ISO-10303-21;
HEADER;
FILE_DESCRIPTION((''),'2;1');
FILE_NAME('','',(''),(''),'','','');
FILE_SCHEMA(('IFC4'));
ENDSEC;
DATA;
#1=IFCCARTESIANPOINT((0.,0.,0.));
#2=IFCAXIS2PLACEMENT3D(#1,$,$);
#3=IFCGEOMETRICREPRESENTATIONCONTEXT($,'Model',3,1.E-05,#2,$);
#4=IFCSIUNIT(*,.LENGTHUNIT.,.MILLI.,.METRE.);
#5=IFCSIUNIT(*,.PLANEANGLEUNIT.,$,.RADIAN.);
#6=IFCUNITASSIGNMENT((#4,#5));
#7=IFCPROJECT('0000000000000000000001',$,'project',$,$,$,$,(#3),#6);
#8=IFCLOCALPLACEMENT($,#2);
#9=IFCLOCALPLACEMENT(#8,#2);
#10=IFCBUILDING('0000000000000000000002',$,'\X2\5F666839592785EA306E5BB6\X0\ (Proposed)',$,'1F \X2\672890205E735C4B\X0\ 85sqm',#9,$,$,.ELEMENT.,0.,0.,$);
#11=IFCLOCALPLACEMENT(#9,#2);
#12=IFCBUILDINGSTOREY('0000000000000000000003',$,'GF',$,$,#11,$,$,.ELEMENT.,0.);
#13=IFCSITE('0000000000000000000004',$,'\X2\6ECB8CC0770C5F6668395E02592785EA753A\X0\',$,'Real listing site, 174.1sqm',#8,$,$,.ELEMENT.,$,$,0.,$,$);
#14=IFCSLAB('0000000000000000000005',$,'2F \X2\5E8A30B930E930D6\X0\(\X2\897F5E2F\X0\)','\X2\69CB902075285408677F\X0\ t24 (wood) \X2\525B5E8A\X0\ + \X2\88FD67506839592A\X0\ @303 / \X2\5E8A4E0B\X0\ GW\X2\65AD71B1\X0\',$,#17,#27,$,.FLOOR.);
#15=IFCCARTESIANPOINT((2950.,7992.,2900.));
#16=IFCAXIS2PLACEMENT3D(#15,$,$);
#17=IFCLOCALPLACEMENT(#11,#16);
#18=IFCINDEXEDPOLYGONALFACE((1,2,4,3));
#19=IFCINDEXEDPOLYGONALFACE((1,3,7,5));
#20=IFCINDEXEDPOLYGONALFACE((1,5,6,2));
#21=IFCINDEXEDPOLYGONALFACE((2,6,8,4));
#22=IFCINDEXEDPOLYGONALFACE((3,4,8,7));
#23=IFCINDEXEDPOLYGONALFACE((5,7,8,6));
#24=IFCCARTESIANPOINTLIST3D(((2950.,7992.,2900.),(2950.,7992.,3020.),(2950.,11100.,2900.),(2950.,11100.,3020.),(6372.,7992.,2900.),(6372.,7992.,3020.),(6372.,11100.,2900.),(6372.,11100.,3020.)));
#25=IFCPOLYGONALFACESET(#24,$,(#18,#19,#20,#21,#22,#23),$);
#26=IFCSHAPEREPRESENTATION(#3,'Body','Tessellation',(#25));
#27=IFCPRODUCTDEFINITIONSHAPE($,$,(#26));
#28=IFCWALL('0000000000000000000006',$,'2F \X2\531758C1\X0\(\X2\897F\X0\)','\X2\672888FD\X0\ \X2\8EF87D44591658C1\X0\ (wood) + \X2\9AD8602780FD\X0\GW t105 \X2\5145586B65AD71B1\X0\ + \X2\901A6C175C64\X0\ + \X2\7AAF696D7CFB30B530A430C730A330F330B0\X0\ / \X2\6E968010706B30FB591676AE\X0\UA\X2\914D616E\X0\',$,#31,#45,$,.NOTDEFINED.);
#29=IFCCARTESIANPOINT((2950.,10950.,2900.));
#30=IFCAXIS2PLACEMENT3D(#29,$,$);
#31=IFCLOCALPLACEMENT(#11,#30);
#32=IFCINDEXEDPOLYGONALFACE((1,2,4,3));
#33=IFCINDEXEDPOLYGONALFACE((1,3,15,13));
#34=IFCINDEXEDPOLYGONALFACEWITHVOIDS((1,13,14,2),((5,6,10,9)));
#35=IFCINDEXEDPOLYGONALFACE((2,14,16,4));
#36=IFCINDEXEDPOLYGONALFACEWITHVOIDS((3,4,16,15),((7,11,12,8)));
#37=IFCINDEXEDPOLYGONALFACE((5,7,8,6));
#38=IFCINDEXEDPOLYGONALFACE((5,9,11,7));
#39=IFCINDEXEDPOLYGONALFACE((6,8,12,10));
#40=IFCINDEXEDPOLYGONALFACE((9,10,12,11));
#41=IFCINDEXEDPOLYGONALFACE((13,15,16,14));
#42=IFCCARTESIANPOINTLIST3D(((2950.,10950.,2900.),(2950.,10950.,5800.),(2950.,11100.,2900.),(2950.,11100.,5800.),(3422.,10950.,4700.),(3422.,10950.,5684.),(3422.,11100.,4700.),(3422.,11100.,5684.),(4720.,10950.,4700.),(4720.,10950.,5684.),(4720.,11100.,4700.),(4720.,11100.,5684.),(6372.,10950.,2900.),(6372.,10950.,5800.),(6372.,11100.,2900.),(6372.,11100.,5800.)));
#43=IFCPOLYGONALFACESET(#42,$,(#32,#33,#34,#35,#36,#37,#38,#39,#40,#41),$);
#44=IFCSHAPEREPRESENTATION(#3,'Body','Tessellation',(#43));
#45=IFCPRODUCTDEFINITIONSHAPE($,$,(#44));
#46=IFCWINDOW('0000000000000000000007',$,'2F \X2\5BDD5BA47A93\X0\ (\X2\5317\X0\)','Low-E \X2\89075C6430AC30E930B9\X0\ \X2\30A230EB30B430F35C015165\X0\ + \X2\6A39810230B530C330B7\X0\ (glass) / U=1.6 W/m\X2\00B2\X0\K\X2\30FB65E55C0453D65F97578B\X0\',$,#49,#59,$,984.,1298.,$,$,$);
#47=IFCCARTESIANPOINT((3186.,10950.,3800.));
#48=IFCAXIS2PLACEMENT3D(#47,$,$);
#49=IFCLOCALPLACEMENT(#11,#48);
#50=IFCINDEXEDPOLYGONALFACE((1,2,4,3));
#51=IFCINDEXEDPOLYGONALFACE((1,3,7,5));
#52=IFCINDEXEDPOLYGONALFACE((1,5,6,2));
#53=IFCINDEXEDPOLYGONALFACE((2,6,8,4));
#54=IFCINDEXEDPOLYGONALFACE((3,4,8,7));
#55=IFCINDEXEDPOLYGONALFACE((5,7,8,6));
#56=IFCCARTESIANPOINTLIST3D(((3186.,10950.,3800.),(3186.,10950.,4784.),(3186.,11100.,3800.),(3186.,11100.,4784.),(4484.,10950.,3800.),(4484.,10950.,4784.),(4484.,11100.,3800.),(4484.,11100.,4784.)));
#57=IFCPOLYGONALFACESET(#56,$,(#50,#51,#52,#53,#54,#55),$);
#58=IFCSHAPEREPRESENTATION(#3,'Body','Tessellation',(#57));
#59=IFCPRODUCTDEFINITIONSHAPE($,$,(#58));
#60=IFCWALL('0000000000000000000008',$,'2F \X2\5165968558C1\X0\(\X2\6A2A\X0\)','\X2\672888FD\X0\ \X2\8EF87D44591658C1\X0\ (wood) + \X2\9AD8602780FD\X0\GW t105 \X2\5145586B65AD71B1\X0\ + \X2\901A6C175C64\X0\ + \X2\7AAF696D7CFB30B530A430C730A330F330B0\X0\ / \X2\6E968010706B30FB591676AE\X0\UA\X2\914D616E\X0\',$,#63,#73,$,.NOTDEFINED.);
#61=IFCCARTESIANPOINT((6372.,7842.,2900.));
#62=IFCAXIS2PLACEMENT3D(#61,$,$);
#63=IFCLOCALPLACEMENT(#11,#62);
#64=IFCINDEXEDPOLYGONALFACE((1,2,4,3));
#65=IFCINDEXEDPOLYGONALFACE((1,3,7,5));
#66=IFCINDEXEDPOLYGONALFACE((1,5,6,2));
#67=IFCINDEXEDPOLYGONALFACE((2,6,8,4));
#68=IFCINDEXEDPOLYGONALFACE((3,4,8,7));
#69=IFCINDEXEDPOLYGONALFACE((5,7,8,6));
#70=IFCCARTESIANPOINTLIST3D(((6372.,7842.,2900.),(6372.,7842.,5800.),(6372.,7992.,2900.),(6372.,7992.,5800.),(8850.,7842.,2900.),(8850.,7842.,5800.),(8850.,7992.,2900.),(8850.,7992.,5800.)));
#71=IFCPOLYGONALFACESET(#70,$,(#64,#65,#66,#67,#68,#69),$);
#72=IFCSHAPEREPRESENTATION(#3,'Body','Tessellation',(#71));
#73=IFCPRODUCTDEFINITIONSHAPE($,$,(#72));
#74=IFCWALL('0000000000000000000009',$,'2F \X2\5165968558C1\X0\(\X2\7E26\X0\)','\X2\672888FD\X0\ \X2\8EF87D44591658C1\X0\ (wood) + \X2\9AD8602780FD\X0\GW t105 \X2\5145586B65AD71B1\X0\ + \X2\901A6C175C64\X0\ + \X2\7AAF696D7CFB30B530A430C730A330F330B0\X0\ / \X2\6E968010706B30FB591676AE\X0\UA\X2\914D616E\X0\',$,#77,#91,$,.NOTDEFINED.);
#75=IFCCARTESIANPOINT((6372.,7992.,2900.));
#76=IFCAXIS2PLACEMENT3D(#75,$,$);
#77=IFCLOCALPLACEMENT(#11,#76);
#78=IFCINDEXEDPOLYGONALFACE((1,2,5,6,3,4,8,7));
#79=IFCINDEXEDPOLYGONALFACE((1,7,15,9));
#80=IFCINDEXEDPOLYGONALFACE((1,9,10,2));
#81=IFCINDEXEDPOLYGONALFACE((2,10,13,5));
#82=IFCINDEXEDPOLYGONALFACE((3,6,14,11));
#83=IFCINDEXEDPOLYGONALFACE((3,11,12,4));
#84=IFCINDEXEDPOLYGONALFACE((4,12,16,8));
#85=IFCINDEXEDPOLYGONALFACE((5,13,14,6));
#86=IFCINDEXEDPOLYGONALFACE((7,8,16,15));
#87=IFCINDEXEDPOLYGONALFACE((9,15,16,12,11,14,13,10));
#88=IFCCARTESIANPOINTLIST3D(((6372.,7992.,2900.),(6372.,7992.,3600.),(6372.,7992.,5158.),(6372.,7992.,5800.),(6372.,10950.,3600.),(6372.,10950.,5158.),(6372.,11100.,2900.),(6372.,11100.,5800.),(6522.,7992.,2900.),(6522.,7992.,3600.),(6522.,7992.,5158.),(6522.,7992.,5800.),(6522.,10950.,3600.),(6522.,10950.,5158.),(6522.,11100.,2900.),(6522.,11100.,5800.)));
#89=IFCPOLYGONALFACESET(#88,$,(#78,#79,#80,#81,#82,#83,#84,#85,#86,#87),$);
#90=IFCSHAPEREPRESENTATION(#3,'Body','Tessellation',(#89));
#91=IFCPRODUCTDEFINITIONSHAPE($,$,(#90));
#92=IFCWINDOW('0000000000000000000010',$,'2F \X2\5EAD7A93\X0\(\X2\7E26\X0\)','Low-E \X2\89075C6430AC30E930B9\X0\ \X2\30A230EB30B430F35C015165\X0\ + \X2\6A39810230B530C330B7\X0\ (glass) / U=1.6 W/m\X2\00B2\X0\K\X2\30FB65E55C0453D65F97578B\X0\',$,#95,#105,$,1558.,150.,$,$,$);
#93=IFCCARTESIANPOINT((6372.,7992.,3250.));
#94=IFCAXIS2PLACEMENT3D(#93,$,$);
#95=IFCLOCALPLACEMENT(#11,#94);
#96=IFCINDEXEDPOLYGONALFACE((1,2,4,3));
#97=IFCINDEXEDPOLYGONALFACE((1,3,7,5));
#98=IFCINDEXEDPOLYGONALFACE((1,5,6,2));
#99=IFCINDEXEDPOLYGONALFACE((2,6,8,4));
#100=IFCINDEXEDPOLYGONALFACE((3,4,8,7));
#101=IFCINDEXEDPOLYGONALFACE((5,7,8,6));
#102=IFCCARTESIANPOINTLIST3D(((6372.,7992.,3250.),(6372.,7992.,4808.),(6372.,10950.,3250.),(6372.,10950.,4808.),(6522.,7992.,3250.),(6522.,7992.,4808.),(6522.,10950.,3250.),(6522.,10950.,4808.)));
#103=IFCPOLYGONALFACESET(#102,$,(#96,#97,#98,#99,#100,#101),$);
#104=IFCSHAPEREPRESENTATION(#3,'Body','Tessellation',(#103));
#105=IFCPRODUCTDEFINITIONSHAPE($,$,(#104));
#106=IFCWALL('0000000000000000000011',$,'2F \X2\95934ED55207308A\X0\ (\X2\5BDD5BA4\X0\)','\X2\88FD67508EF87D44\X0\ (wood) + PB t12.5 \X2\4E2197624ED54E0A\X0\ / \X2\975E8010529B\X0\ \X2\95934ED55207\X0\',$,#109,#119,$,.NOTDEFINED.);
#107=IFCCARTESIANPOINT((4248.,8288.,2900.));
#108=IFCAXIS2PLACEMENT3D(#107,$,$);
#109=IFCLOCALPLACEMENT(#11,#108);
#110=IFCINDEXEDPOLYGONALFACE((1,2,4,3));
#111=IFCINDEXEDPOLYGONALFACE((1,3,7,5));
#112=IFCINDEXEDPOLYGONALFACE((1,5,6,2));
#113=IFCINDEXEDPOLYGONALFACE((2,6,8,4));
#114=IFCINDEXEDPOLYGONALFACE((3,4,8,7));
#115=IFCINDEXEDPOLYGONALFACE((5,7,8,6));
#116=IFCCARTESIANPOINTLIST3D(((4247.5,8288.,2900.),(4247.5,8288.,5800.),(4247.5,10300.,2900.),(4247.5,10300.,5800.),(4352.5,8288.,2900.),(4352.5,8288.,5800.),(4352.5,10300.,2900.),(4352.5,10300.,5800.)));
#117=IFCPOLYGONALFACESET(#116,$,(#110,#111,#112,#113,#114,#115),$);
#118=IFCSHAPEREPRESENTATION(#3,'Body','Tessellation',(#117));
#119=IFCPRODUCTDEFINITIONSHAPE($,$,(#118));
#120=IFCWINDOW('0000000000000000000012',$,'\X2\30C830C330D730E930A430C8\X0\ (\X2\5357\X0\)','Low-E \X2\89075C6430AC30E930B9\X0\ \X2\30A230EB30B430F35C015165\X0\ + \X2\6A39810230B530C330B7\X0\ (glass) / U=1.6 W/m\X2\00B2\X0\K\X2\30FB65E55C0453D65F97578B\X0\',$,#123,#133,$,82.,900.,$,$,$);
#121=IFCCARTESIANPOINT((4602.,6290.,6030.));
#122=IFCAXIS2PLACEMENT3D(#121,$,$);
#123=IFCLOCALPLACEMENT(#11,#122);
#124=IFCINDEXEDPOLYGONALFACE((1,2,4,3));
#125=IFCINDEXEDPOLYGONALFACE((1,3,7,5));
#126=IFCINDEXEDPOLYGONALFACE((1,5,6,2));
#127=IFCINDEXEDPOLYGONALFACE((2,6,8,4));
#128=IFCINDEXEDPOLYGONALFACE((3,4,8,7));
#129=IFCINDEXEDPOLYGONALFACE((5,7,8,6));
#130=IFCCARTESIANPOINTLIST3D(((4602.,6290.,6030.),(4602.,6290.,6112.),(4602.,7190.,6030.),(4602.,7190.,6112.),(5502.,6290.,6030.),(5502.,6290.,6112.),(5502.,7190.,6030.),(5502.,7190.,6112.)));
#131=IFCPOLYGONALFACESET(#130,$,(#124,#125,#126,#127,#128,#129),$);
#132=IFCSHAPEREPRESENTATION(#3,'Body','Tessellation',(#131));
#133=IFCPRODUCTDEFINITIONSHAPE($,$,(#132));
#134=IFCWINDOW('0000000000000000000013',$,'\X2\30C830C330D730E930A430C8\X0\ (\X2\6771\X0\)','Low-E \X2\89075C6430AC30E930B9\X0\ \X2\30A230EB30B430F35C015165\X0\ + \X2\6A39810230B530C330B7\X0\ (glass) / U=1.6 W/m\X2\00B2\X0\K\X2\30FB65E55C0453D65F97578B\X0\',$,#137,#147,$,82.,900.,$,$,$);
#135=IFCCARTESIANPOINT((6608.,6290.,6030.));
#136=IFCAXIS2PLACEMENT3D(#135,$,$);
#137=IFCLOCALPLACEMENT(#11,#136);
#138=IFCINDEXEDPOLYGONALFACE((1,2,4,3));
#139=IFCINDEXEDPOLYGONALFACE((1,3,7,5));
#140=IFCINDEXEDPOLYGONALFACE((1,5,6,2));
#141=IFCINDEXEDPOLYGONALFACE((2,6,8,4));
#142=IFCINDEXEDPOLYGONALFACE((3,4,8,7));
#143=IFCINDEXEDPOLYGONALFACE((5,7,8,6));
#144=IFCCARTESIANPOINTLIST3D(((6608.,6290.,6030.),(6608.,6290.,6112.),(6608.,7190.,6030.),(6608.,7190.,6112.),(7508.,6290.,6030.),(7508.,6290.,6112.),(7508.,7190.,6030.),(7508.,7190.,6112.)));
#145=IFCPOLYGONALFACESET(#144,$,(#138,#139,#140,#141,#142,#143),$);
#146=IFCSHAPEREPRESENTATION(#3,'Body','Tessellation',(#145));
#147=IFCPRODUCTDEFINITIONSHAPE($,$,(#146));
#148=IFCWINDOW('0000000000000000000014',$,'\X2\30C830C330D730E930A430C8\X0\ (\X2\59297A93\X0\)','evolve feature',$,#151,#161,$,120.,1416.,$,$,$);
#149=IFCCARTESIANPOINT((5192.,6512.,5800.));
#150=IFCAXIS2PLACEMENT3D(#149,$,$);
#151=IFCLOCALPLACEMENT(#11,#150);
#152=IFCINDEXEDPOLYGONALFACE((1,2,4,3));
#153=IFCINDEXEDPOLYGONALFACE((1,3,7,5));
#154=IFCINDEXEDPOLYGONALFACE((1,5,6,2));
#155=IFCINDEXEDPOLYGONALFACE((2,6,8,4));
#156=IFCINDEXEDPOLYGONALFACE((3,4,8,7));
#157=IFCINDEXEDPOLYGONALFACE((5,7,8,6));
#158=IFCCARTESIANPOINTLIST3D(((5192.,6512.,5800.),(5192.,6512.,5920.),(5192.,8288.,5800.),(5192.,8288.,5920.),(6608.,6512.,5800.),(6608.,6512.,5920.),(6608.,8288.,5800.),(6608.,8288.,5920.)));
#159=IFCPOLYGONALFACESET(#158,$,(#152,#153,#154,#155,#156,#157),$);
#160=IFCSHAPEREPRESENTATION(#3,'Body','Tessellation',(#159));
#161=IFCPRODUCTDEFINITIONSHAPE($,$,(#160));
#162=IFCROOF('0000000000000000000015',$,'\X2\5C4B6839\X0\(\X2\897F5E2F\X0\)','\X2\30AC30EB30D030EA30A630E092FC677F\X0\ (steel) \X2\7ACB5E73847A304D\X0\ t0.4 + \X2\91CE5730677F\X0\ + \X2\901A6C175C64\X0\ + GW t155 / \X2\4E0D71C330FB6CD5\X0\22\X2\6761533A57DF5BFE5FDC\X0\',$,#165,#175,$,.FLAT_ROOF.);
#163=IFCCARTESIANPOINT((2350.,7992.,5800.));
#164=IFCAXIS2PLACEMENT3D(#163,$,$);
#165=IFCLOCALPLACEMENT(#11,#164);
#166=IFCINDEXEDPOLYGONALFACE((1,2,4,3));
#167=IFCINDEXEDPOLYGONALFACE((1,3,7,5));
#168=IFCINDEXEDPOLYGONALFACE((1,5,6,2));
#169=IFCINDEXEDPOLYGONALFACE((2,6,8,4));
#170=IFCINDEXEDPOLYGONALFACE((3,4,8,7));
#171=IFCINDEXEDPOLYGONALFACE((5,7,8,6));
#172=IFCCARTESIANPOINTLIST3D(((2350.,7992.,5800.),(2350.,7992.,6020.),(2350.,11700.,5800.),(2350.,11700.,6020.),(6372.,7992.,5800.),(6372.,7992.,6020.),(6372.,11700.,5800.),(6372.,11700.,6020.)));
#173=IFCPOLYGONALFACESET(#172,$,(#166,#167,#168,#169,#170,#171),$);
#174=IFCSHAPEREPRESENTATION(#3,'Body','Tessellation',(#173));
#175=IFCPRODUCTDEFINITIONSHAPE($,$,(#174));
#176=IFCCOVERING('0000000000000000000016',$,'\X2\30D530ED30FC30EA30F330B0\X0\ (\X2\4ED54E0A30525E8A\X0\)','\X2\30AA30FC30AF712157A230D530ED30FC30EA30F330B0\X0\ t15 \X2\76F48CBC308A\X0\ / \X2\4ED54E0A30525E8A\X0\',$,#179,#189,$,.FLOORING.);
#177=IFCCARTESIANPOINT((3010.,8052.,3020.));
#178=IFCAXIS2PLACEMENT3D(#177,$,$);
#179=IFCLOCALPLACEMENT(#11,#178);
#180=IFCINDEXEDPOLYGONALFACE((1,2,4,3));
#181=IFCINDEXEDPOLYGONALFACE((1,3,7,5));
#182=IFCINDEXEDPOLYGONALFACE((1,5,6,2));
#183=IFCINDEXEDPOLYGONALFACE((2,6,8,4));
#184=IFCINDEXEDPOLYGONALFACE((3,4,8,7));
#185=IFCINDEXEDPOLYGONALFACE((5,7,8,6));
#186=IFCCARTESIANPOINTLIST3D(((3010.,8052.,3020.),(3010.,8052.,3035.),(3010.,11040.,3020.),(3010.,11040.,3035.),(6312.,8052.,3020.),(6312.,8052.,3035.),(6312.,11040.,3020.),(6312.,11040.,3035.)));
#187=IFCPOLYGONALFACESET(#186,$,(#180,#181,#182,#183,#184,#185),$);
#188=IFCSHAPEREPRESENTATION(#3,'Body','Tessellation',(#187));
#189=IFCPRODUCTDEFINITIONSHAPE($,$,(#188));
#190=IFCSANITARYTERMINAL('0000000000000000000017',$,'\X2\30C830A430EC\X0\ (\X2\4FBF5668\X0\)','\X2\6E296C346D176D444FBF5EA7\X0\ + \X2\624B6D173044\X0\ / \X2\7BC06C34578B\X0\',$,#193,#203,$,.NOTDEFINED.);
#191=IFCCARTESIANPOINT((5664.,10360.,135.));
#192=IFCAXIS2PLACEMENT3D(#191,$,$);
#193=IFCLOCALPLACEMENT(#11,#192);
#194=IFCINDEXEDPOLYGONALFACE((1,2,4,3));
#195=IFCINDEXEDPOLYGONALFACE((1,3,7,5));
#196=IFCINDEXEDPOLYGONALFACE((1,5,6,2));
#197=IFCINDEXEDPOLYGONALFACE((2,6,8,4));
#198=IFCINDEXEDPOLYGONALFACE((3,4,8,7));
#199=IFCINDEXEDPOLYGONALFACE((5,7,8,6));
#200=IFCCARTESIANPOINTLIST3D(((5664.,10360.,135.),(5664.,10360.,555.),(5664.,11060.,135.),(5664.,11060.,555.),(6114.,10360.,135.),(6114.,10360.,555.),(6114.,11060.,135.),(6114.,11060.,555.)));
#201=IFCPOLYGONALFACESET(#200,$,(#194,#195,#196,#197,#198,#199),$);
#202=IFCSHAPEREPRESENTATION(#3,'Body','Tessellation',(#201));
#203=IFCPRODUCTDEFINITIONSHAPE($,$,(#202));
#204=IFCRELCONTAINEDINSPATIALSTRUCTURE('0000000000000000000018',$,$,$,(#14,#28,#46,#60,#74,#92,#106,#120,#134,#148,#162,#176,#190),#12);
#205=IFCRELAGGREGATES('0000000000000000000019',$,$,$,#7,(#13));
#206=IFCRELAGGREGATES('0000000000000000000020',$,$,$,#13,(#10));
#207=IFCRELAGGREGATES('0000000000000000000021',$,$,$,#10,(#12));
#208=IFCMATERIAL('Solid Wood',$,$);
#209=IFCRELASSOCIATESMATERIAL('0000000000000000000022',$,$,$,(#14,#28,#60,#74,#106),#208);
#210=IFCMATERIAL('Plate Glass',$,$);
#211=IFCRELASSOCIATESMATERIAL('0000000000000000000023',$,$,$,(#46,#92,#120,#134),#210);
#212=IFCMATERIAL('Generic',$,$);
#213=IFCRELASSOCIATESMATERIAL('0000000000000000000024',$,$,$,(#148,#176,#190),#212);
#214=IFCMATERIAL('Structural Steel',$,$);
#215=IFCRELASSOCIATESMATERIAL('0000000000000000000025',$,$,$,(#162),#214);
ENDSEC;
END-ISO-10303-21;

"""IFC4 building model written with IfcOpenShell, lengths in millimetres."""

from ifc_helpers import new_model, si_unit, frame, frame_2d, origin, place, context, project, spatial, rectangle, extrude, material, element, fill, save


model = new_model("IFC4")

# Units and contexts
model_context = context("Model", 3, precision=1e-05, world=origin())
ifc_project = project(units=[si_unit("LENGTHUNIT", "METRE", prefix="MILLI"), si_unit("PLANEANGLEUNIT", "RADIAN")], contexts=[model_context])

# Site, building, storey
site_placement = place(None, origin())
site = spatial("IfcSite", under=ifc_project, at=site_placement, Name="滋賀県彦根市大藪町", ObjectType="Real listing site, 174.1sqm", CompositionType="ELEMENT", RefElevation=0.0)
building_placement = place(site_placement, origin())
building = spatial("IfcBuilding", under=site, at=building_placement, Name="彦根大藪の家 (Proposed)", ObjectType="1F 木造平屋 85sqm", CompositionType="ELEMENT", ElevationOfRefHeight=0.0, ElevationOfTerrain=0.0)
storey_placement = place(building_placement, origin())
storey = spatial("IfcBuildingStorey", under=building, at=storey_placement, Name="GF", CompositionType="ELEMENT", Elevation=0.0)

# Slab
ifc_material_1 = material(Name="Solid Wood")
slab_placement = place(storey_placement, frame((2950.0, 7992.0, 2900.0)))
element("IfcSlab", 1, at=slab_placement, inside=storey, material=ifc_material_1, Name="2F 床スラブ(西帯)", Description="構造用合板 t24 (wood) 剛床 + 製材根太 @303 / 床下 GW断熱", PredefinedType="FLOOR", context=model_context, shape_type="SweptSolid", body=[
    extrude(rectangle(XDim=3422.0, YDim=3108.0, at=frame_2d((1711.0, 1554.0))), frame((2950.0, 7992.0, 2900.0)), (0.0, 0.0, 1.0), 120.0),
])

# Wall, opening, window
wall_1_placement = place(storey_placement, frame((2950.0, 10950.0, 2900.0)))
wall_1 = element("IfcWall", 2, at=wall_1_placement, inside=storey, material=ifc_material_1, Name="2F 北壁(西)", Description="木製 軸組外壁 (wood) + 高性能GW t105 充填断熱 + 通気層 + 窯業系サイディング / 準耐火・外皮UA配慮", PredefinedType="NOTDEFINED", context=model_context, shape_type="SweptSolid", body=[
    extrude(rectangle(XDim=3422.0, YDim=150.0, at=frame_2d((1711.0, 75.0))), frame((2950.0, 10950.0, 2900.0)), (0.0, 0.0, 1.0), 2900.0),
])
opening_1_placement = place(storey_placement, frame((3186.0, 10950.0, 3800.0)))
opening_1 = element("IfcOpeningElement", 3, at=opening_1_placement, cuts=wall_1, PredefinedType="NOTDEFINED", context=model_context, shape_type="SweptSolid", body=[
    extrude(rectangle(XDim=1298.0, YDim=150.0, at=frame_2d((649.0, 75.0))), frame((3186.0, 10950.0, 3800.0)), (0.0, 0.0, 1.0), 984.0),
])
ifc_material_2 = material(Name="Plate Glass")
window_1_placement = place(storey_placement, frame((3186.0, 10950.0, 3800.0)))
window_1 = element("IfcWindow", 4, at=window_1_placement, inside=storey, material=ifc_material_2, Name="2F 寝室窓 (北)", Description="Low-E 複層ガラス アルゴン封入 + 樹脂サッシ (glass) / U=1.6 W/m²K・日射取得型", OverallHeight=984.0, OverallWidth=1298.0, context=model_context, shape_type="SweptSolid", body=[
    extrude(rectangle(XDim=1298.0, YDim=150.0, at=frame_2d((649.0, 75.0))), frame((3186.0, 10950.0, 3800.0)), (0.0, 0.0, 1.0), 984.0),
])
fill(opening_1, window_1)

# Wall
wall_2_placement = place(storey_placement, frame((6372.0, 7842.0, 2900.0)))
element("IfcWall", 5, at=wall_2_placement, inside=storey, material=ifc_material_1, Name="2F 入隅壁(横)", Description="木製 軸組外壁 (wood) + 高性能GW t105 充填断熱 + 通気層 + 窯業系サイディング / 準耐火・外皮UA配慮", PredefinedType="NOTDEFINED", context=model_context, shape_type="SweptSolid", body=[
    extrude(rectangle(XDim=2478.0, YDim=150.0, at=frame_2d((1239.0, 75.0))), frame((6372.0, 7842.0, 2900.0)), (0.0, 0.0, 1.0), 2900.0),
])

# Wall, opening, window
wall_3_placement = place(storey_placement, frame((6372.0, 7992.0, 2900.0)))
wall_3 = element("IfcWall", 6, at=wall_3_placement, inside=storey, material=ifc_material_1, Name="2F 入隅壁(縦)", Description="木製 軸組外壁 (wood) + 高性能GW t105 充填断熱 + 通気層 + 窯業系サイディング / 準耐火・外皮UA配慮", PredefinedType="NOTDEFINED", context=model_context, shape_type="SweptSolid", body=[
    extrude(rectangle(XDim=150.0, YDim=3108.0, at=frame_2d((75.0, 1554.0))), frame((6372.0, 7992.0, 2900.0)), (0.0, 0.0, 1.0), 2900.0),
])
opening_2_placement = place(storey_placement, frame((6372.0, 7992.0, 3250.0)))
opening_2 = element("IfcOpeningElement", 7, at=opening_2_placement, cuts=wall_3, PredefinedType="NOTDEFINED", context=model_context, shape_type="SweptSolid", body=[
    extrude(rectangle(XDim=150.0, YDim=2958.0, at=frame_2d((75.0, 1479.0))), frame((6372.0, 7992.0, 3250.0)), (0.0, 0.0, 1.0), 1558.0),
])
window_2_placement = place(storey_placement, frame((6372.0, 7992.0, 3250.0)))
window_2 = element("IfcWindow", 8, at=window_2_placement, inside=storey, material=ifc_material_2, Name="2F 庭窓(縦)", Description="Low-E 複層ガラス アルゴン封入 + 樹脂サッシ (glass) / U=1.6 W/m²K・日射取得型", OverallHeight=1558.0, OverallWidth=150.0, context=model_context, shape_type="SweptSolid", body=[
    extrude(rectangle(XDim=150.0, YDim=2958.0, at=frame_2d((75.0, 1479.0))), frame((6372.0, 7992.0, 3250.0)), (0.0, 0.0, 1.0), 1558.0),
])
fill(opening_2, window_2)

# Wall
wall_4_placement = place(storey_placement, frame((4248.0, 8288.0, 2900.0)))
element("IfcWall", 9, at=wall_4_placement, inside=storey, material=ifc_material_1, Name="2F 間仕切り (寝室)", Description="製材軸組 (wood) + PB t12.5 両面仕上 / 非耐力 間仕切", PredefinedType="NOTDEFINED", context=model_context, shape_type="SweptSolid", body=[
    extrude(rectangle(XDim=105.0, YDim=2012.0, at=frame_2d((52.0, 1006.0))), frame((4248.0, 8288.0, 2900.0)), (0.0, 0.0, 1.0), 2900.0),
])

# Windows
window_3_placement = place(storey_placement, frame((4602.0, 6290.0, 6030.0)))
element("IfcWindow", 10, at=window_3_placement, inside=storey, material=ifc_material_2, Name="トップライト (南)", Description="Low-E 複層ガラス アルゴン封入 + 樹脂サッシ (glass) / U=1.6 W/m²K・日射取得型", OverallHeight=82.0, OverallWidth=900.0, context=model_context, shape_type="SweptSolid", body=[
    extrude(rectangle(XDim=900.0, YDim=900.0, at=frame_2d((450.0, 450.0))), frame((4602.0, 6290.0, 6030.0)), (0.0, 0.0, 1.0), 82.0),
])
window_4_placement = place(storey_placement, frame((6608.0, 6290.0, 6030.0)))
element("IfcWindow", 11, at=window_4_placement, inside=storey, material=ifc_material_2, Name="トップライト (東)", Description="Low-E 複層ガラス アルゴン封入 + 樹脂サッシ (glass) / U=1.6 W/m²K・日射取得型", OverallHeight=82.0, OverallWidth=900.0, context=model_context, shape_type="SweptSolid", body=[
    extrude(rectangle(XDim=900.0, YDim=900.0, at=frame_2d((450.0, 450.0))), frame((6608.0, 6290.0, 6030.0)), (0.0, 0.0, 1.0), 82.0),
])
ifc_material_3 = material(Name="Generic")
window_5_placement = place(storey_placement, frame((5192.0, 6512.0, 5800.0)))
element("IfcWindow", 12, at=window_5_placement, inside=storey, material=ifc_material_3, Name="トップライト (天窓)", Description="evolve feature", OverallHeight=120.0, OverallWidth=1416.0, context=model_context, shape_type="SweptSolid", body=[
    extrude(rectangle(XDim=1416.0, YDim=1776.0, at=frame_2d((708.0, 888.0))), frame((5192.0, 6512.0, 5800.0)), (0.0, 0.0, 1.0), 120.0),
])

# Roof
ifc_material_4 = material(Name="Structural Steel")
for number, where, name in (
    (13, (2350.0, 7992.0, 5800.0), "屋根(西帯)"),
):
    element("IfcRoof", number, at=place(storey_placement, frame(where)), inside=storey, material=ifc_material_4, Name=name, Description="ガルバリウム鋼板 (steel) 立平葺き t0.4 + 野地板 + 通気層 + GW t155 / 不燃・法22条区域対応", PredefinedType="FLAT_ROOF", context=model_context, shape_type="SweptSolid", body=[
        extrude(rectangle(XDim=4022.0, YDim=3708.0, at=frame_2d((2011.0, 1854.0))), frame((2350.0, 7992.0, 5800.0)), (0.0, 0.0, 1.0), 220.0),
    ])

# Covering
covering_placement = place(storey_placement, frame((3010.0, 8052.0, 3020.0)))
element("IfcCovering", 14, at=covering_placement, inside=storey, material=ifc_material_3, Name="フローリング (仕上げ床)", Description="オーク無垢フローリング t15 直貼り / 仕上げ床", PredefinedType="FLOORING", context=model_context, shape_type="SweptSolid", body=[
    extrude(rectangle(XDim=3302.0, YDim=2988.0, at=frame_2d((1651.0, 1494.0))), frame((3010.0, 8052.0, 3020.0)), (0.0, 0.0, 1.0), 15.0),
])

# Sanitary terminal
sanitary_terminal_placement = place(storey_placement, frame((5664.0, 10360.0, 135.0)))
element("IfcSanitaryTerminal", 15, at=sanitary_terminal_placement, inside=storey, material=ifc_material_3, Name="トイレ (便器)", Description="温水洗浄便座 + 手洗い / 節水型", PredefinedType="NOTDEFINED", context=model_context, shape_type="SweptSolid", body=[
    extrude(rectangle(XDim=450.0, YDim=700.0, at=frame_2d((225.0, 350.0))), frame((5664.0, 10360.0, 135.0)), (0.0, 0.0, 1.0), 420.0),
])

save(model, "model.ifc")
